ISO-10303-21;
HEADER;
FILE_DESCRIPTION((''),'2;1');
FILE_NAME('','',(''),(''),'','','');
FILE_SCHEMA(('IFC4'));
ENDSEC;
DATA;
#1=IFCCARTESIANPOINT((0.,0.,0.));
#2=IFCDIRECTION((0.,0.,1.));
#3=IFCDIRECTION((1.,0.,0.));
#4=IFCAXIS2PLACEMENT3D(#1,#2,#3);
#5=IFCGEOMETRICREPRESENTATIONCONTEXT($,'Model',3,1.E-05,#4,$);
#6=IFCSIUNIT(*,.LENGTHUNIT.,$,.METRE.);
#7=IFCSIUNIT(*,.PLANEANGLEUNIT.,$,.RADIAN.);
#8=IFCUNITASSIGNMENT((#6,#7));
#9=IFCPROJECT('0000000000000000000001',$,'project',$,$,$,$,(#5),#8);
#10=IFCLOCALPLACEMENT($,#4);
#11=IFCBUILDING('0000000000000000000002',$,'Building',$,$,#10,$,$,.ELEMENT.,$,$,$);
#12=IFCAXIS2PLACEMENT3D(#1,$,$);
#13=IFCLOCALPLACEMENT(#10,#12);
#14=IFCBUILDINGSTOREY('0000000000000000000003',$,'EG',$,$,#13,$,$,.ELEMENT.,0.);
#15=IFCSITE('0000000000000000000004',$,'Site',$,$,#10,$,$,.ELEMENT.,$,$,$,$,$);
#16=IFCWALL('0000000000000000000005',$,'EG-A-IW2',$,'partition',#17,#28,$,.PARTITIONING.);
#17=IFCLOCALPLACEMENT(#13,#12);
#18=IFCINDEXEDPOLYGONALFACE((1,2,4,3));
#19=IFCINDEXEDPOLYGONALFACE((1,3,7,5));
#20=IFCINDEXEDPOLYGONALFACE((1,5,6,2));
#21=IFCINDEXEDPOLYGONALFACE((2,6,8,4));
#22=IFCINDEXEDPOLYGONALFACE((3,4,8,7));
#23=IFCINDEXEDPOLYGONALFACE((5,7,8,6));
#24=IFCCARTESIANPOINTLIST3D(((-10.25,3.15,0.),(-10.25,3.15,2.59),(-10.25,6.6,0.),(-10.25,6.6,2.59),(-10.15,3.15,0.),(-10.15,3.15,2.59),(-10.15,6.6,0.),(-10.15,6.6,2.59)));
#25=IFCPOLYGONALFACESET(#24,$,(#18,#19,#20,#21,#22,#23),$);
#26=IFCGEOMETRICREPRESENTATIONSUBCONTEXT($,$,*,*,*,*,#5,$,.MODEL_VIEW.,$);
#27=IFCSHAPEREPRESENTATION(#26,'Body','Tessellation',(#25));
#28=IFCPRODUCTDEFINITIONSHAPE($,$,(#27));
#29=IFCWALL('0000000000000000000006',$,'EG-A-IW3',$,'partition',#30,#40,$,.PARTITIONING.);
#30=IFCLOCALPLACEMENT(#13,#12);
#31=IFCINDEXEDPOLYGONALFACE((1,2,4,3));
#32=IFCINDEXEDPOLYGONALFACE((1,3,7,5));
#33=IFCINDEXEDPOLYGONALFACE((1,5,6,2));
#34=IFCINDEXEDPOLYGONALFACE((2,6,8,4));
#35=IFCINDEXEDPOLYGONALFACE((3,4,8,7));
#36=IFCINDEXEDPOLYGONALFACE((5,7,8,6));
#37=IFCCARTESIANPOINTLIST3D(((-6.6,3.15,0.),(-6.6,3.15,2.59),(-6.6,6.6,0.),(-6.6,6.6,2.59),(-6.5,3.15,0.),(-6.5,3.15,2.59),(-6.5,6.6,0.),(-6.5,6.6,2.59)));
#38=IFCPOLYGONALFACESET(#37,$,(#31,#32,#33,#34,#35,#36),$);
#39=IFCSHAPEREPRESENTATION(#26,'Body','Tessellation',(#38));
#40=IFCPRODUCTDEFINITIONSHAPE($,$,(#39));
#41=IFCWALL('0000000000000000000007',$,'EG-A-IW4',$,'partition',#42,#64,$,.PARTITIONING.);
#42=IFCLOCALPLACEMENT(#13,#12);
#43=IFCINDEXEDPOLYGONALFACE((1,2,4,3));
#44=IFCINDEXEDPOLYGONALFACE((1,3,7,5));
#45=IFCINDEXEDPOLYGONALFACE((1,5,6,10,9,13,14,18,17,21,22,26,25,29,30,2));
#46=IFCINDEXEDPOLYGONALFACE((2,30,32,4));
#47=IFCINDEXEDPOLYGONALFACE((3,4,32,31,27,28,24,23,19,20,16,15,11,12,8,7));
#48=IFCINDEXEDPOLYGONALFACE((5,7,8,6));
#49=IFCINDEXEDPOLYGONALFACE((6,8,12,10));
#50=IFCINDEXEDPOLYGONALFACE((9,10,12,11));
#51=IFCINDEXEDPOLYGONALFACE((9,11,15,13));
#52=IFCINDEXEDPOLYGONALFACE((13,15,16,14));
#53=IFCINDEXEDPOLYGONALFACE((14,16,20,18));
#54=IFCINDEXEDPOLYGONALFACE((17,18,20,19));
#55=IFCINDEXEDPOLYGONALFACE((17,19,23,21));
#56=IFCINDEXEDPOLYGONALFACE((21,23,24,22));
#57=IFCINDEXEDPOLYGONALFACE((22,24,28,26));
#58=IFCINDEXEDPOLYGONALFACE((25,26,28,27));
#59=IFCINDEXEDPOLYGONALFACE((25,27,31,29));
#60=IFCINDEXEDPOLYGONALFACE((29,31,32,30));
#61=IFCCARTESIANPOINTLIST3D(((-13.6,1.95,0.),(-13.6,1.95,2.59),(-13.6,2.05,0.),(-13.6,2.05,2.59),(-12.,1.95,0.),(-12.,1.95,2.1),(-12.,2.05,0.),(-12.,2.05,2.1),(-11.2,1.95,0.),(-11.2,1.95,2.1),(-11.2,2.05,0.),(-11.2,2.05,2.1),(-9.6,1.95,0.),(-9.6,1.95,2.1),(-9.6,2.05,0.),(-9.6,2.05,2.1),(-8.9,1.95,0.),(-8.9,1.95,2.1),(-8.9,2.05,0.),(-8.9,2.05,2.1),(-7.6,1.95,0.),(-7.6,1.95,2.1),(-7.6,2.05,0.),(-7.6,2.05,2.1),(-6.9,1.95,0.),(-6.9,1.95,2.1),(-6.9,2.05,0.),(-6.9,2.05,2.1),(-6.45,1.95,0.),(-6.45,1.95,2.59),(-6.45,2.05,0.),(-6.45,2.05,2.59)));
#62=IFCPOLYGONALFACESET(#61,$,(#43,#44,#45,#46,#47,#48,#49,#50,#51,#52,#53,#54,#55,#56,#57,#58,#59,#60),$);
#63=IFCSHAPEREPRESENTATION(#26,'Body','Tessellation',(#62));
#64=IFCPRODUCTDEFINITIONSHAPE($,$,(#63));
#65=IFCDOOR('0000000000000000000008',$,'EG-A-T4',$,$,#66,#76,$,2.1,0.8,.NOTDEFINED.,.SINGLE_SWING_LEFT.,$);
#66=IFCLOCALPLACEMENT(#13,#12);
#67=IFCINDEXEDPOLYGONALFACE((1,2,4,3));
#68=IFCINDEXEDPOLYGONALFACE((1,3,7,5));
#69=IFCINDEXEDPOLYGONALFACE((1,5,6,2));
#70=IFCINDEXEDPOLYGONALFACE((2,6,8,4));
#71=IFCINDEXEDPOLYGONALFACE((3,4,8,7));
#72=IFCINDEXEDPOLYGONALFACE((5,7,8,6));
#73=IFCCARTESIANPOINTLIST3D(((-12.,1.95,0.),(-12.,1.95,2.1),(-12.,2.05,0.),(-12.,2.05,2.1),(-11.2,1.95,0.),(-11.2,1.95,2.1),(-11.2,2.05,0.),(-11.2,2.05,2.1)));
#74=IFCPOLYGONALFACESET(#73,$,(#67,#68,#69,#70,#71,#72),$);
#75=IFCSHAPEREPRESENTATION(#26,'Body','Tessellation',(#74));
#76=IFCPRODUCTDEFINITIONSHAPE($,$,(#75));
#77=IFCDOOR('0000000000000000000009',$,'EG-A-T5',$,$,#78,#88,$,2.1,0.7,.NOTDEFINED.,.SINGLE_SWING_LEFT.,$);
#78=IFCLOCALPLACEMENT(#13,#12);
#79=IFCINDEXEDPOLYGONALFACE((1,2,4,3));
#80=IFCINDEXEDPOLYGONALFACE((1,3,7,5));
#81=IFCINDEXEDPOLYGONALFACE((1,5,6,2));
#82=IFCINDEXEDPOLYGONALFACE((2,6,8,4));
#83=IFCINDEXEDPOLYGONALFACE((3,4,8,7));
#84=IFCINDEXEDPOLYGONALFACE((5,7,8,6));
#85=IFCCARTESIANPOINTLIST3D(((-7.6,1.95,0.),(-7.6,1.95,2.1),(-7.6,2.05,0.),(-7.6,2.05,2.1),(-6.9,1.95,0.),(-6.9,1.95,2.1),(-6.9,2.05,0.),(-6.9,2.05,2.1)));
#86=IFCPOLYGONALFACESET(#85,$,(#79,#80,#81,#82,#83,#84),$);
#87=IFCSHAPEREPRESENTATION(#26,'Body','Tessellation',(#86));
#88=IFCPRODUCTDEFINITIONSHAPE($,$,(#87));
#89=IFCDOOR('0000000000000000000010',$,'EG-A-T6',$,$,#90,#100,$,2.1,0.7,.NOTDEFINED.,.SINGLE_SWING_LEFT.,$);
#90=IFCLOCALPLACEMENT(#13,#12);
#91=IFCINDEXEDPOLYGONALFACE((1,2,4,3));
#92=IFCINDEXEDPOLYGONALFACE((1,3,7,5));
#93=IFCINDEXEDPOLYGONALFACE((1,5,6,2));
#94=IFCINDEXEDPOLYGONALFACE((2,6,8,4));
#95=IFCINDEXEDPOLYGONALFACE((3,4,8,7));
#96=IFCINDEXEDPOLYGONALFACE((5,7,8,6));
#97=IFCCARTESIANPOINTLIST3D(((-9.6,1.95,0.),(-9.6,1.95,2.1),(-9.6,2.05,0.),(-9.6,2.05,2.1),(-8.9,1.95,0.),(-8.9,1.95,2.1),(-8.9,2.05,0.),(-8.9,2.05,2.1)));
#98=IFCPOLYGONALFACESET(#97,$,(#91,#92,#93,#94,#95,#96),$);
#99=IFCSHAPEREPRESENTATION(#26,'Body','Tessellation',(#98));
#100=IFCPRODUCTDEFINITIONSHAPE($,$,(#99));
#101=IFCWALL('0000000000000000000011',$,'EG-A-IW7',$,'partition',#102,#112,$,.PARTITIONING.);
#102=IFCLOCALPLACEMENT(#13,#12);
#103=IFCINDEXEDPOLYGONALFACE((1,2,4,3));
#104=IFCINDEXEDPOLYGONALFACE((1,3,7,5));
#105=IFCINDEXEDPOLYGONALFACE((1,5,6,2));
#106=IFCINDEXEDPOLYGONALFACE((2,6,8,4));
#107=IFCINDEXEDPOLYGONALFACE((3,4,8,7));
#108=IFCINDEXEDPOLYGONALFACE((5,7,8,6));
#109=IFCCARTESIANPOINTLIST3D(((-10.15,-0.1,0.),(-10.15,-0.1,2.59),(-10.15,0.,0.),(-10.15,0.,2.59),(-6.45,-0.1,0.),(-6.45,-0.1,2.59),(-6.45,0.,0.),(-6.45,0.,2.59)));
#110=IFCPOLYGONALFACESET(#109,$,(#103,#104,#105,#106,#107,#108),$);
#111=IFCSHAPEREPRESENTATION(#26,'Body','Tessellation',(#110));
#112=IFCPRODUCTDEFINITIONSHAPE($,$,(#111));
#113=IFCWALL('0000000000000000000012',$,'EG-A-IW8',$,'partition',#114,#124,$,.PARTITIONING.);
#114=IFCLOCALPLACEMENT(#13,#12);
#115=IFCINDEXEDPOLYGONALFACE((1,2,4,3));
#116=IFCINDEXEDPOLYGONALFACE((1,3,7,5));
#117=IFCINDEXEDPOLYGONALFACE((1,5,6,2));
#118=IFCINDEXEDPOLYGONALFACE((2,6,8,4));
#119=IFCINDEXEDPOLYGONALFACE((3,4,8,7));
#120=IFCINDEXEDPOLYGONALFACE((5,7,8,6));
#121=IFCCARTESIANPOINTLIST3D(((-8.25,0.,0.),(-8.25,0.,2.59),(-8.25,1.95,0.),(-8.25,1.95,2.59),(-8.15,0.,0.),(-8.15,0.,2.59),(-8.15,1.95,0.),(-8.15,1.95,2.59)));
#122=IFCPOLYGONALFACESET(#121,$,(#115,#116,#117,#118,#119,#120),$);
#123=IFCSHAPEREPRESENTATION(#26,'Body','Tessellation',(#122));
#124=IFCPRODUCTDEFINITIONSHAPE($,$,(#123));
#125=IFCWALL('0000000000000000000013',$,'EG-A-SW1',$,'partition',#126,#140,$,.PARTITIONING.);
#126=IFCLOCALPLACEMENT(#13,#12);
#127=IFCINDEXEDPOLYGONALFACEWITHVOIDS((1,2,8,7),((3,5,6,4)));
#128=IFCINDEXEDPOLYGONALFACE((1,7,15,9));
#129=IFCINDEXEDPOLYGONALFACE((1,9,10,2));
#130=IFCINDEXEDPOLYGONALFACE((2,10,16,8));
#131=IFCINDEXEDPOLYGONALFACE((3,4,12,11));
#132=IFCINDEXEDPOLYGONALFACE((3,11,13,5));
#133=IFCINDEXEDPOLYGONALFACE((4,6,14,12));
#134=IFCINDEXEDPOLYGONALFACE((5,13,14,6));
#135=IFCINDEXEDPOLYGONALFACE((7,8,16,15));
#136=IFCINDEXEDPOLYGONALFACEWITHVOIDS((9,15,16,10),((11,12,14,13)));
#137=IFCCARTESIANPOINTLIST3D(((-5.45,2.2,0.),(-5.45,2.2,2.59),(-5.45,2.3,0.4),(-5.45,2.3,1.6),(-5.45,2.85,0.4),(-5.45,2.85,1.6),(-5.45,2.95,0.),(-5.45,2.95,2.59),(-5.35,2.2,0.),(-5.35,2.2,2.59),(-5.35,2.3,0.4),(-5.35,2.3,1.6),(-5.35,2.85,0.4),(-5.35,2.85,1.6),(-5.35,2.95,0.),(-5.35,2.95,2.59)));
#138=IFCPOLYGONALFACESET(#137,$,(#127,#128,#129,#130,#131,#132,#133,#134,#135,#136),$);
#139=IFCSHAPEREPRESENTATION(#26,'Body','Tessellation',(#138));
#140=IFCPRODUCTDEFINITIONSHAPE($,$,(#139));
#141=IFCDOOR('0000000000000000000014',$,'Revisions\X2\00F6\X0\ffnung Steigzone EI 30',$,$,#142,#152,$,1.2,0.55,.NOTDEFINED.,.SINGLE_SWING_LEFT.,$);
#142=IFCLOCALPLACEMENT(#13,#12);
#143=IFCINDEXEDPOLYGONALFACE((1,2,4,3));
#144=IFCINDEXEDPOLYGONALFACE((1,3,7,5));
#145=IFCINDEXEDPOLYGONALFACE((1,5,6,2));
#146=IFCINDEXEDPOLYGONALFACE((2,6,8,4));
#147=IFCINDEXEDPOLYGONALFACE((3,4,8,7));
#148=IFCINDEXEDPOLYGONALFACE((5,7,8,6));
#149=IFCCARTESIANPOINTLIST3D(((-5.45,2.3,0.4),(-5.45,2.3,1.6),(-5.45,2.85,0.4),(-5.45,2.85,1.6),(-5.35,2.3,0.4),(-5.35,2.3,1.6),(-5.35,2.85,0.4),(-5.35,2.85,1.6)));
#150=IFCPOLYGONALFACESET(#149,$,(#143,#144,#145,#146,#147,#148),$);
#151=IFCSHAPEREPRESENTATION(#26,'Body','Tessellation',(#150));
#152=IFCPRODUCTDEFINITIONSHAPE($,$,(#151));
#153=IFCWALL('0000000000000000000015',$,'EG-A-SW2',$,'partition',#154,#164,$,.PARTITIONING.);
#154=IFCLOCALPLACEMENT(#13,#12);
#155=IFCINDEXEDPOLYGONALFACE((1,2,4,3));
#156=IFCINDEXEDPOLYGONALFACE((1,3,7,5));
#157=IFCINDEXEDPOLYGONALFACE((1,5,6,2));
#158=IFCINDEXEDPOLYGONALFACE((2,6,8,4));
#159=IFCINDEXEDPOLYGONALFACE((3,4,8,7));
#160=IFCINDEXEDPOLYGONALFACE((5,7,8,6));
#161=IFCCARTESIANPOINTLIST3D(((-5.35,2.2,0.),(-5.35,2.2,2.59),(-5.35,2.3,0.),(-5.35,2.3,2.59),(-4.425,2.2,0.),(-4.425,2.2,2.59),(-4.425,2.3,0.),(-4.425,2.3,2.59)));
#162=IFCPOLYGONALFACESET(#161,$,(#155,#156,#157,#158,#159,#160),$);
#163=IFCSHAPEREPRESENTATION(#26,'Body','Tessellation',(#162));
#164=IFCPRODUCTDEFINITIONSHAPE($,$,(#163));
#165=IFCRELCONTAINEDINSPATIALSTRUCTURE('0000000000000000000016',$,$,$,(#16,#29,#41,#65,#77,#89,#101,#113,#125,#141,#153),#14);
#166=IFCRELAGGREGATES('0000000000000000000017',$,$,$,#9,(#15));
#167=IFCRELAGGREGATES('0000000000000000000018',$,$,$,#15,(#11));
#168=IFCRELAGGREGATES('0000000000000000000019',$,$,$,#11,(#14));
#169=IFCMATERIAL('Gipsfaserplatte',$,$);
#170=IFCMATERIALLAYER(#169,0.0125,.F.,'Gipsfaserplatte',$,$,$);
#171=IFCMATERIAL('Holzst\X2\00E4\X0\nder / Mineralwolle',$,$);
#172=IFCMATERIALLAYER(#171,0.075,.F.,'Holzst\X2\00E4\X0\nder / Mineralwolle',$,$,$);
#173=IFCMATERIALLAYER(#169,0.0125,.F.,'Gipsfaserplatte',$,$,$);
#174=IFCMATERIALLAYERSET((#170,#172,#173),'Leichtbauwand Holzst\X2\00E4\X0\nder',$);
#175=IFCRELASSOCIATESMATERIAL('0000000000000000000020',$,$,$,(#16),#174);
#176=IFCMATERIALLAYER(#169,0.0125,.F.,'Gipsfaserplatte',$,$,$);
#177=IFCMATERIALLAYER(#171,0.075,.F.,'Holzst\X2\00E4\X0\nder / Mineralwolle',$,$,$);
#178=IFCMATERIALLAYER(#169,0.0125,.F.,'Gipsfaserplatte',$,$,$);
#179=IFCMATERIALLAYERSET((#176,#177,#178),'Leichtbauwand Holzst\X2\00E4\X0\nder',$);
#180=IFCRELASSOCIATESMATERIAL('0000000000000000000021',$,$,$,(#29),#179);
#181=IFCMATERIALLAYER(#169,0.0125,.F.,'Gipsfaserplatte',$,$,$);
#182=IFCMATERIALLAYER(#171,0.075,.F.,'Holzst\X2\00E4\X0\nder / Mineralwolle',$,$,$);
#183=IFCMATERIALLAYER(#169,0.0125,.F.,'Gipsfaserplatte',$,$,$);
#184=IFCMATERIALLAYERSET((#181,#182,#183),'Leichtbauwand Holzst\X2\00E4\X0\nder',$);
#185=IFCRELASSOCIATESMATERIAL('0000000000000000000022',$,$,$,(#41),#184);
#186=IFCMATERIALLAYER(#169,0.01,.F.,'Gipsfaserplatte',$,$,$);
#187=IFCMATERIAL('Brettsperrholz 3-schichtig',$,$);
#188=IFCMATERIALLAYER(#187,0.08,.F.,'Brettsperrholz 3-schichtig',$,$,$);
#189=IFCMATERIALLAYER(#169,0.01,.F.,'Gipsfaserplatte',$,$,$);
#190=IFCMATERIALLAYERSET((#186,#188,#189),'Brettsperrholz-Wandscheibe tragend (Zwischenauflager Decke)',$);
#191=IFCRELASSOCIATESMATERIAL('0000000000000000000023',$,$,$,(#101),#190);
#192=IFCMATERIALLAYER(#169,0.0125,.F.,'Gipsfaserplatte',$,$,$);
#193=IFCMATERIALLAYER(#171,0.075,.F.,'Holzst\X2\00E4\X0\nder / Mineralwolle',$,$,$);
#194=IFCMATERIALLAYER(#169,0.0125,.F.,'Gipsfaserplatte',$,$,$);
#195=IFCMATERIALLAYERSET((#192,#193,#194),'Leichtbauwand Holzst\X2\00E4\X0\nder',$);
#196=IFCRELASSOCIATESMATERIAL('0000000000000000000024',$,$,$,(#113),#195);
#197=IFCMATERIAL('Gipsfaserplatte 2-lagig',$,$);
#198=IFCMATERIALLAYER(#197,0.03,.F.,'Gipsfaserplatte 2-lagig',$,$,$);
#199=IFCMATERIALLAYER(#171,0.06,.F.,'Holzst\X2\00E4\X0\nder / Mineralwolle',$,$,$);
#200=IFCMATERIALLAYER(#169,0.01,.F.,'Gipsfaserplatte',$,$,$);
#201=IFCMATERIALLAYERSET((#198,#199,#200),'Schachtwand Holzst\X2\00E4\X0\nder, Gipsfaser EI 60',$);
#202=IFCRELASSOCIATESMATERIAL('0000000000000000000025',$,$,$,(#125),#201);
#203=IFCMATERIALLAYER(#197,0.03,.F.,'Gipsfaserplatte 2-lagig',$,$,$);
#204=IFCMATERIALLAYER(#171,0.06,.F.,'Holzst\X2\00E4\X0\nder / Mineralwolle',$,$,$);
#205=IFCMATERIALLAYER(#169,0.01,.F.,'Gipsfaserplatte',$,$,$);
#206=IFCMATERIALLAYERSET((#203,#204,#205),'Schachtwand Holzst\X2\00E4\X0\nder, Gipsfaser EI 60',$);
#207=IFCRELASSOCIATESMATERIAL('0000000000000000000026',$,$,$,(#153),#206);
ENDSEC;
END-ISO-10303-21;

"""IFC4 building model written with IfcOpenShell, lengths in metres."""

from ifc_helpers import new_model, si_unit, frame, frame_2d, origin, origin_with_axes, place, context, subcontext, project, spatial, rectangle, extrude, material, layer, layer_set, element, fill, save


model = new_model("IFC4")

# Units and contexts
model_context = context("Model", 3, precision=1e-05, world=origin_with_axes())
sub_context = subcontext(model_context, None, None, "MODEL_VIEW")
ifc_project = project(units=[si_unit("LENGTHUNIT", "METRE"), si_unit("PLANEANGLEUNIT", "RADIAN")], contexts=[model_context])

# Site, building, storey
placement = place(None, origin_with_axes())
site = spatial("IfcSite", under=ifc_project, at=placement, Name="Site", CompositionType="ELEMENT")
building = spatial("IfcBuilding", under=site, at=placement, Name="Building", CompositionType="ELEMENT")
storey_placement = place(placement, origin())
storey = spatial("IfcBuildingStorey", under=building, at=storey_placement, Name="EG", CompositionType="ELEMENT", Elevation=0.0)

# Shared definitions
ifc_material_1 = material(Name="Gipsfaserplatte")

# Shared definitions
ifc_material_2 = material(Name="Gipsfaserplatte 2-lagig")

# Walls
ifc_layer_1 = layer(ifc_material_1, 0.0125, ventilated=False, Name="Gipsfaserplatte")
ifc_material_3 = material(Name="Holzständer / Mineralwolle")
ifc_layer_2 = layer(ifc_material_3, 0.075, ventilated=False, Name="Holzständer / Mineralwolle")
ifc_layer_3 = layer(ifc_material_1, 0.0125, ventilated=False, Name="Gipsfaserplatte")
ifc_layer_set_1 = layer_set([ifc_layer_1, ifc_layer_2, ifc_layer_3], Name="Leichtbauwand Holzständer")
wall_1_placement = place(storey_placement, frame((-10.2, 3.15, 0.0), z_axis=(0.0, 0.0, 1.0), x_axis=(0.0, 1.0, 0.0)))
element("IfcWall", 1, at=wall_1_placement, inside=storey, material=ifc_layer_set_1, Name="EG-A-IW2", ObjectType="partition", PredefinedType="PARTITIONING", context=sub_context, shape_type="SweptSolid", body=[
    extrude(rectangle(XDim=3.45, YDim=0.1, at=frame_2d((1.725, 0.0))), origin(), (0.0, 0.0, 1.0), 2.59),
])
ifc_layer_4 = layer(ifc_material_1, 0.0125, ventilated=False, Name="Gipsfaserplatte")
ifc_layer_5 = layer(ifc_material_3, 0.075, ventilated=False, Name="Holzständer / Mineralwolle")
ifc_layer_6 = layer(ifc_material_1, 0.0125, ventilated=False, Name="Gipsfaserplatte")
ifc_layer_set_2 = layer_set([ifc_layer_4, ifc_layer_5, ifc_layer_6], Name="Leichtbauwand Holzständer")
wall_2_placement = place(storey_placement, frame((-6.55, 3.15, 0.0), z_axis=(0.0, 0.0, 1.0), x_axis=(0.0, 1.0, 0.0)))
element("IfcWall", 2, at=wall_2_placement, inside=storey, material=ifc_layer_set_2, Name="EG-A-IW3", ObjectType="partition", PredefinedType="PARTITIONING", context=sub_context, shape_type="SweptSolid", body=[
    extrude(rectangle(XDim=3.45, YDim=0.1, at=frame_2d((1.725, 0.0))), origin(), (0.0, 0.0, 1.0), 2.59),
])

# Wall, openings, doors
ifc_layer_7 = layer(ifc_material_1, 0.0125, ventilated=False, Name="Gipsfaserplatte")
ifc_layer_8 = layer(ifc_material_3, 0.075, ventilated=False, Name="Holzständer / Mineralwolle")
ifc_layer_9 = layer(ifc_material_1, 0.0125, ventilated=False, Name="Gipsfaserplatte")
ifc_layer_set_3 = layer_set([ifc_layer_7, ifc_layer_8, ifc_layer_9], Name="Leichtbauwand Holzständer")
wall_3_placement = place(storey_placement, frame((-13.6, 2.0, 0.0), z_axis=(0.0, 0.0, 1.0), x_axis=(1.0, 0.0, 0.0)))
wall_3 = element("IfcWall", 3, at=wall_3_placement, inside=storey, material=ifc_layer_set_3, Name="EG-A-IW4", ObjectType="partition", PredefinedType="PARTITIONING", context=sub_context, shape_type="SweptSolid", body=[
    extrude(rectangle(XDim=7.15, YDim=0.1, at=frame_2d((3.575, 0.0))), origin(), (0.0, 0.0, 1.0), 2.59),
])
opening_1_placement = place(wall_3_placement, frame((2.0, 0.1, 0.0), z_axis=(0.0, -1.0, 0.0), x_axis=(1.0, 0.0, 0.0)))
opening_1 = element("IfcOpeningElement", 4, at=opening_1_placement, cuts=wall_3, PredefinedType="OPENING", context=sub_context, shape_type="SweptSolid", body=[
    extrude(rectangle(XDim=0.8, YDim=2.1, at=frame_2d((0.0, 1.05))), origin(), (0.0, 0.0, 1.0), 0.2),
])
opening_2_placement = place(wall_3_placement, frame((6.35, 0.1, 0.0), z_axis=(0.0, -1.0, 0.0), x_axis=(1.0, 0.0, 0.0)))
opening_2 = element("IfcOpeningElement", 5, at=opening_2_placement, cuts=wall_3, PredefinedType="OPENING", context=sub_context, shape_type="SweptSolid", body=[
    extrude(rectangle(XDim=0.7, YDim=2.1, at=frame_2d((0.0, 1.05))), origin(), (0.0, 0.0, 1.0), 0.2),
])
opening_3_placement = place(wall_3_placement, frame((4.35, 0.1, 0.0), z_axis=(0.0, -1.0, 0.0), x_axis=(1.0, 0.0, 0.0)))
opening_3 = element("IfcOpeningElement", 6, at=opening_3_placement, cuts=wall_3, PredefinedType="OPENING", context=sub_context, shape_type="SweptSolid", body=[
    extrude(rectangle(XDim=0.7, YDim=2.1, at=frame_2d((0.0, 1.05))), origin(), (0.0, 0.0, 1.0), 0.2),
])
door_1_placement = place(wall_3_placement, frame((2.0, 0.05, 0.0), z_axis=(0.0, -1.0, 0.0), x_axis=(1.0, 0.0, 0.0)))
door_1 = element("IfcDoor", 7, at=door_1_placement, inside=storey, Name="EG-A-T4", OperationType="SINGLE_SWING_LEFT", OverallHeight=2.1, OverallWidth=0.8, PredefinedType="NOTDEFINED", context=sub_context, shape_type="SweptSolid", body=[
    extrude(rectangle(XDim=0.8, YDim=2.1, at=frame_2d((0.0, 1.05))), origin(), (0.0, 0.0, 1.0), 0.1),
])
fill(opening_1, door_1)
door_2_placement = place(wall_3_placement, frame((6.35, 0.05, 0.0), z_axis=(0.0, -1.0, 0.0), x_axis=(1.0, 0.0, 0.0)))
door_2 = element("IfcDoor", 8, at=door_2_placement, inside=storey, Name="EG-A-T5", OperationType="SINGLE_SWING_LEFT", OverallHeight=2.1, OverallWidth=0.7, PredefinedType="NOTDEFINED", context=sub_context, shape_type="SweptSolid", body=[
    extrude(rectangle(XDim=0.7, YDim=2.1, at=frame_2d((0.0, 1.05))), origin(), (0.0, 0.0, 1.0), 0.1),
])
fill(opening_2, door_2)
door_3_placement = place(wall_3_placement, frame((4.35, 0.05, 0.0), z_axis=(0.0, -1.0, 0.0), x_axis=(1.0, 0.0, 0.0)))
door_3 = element("IfcDoor", 9, at=door_3_placement, inside=storey, Name="EG-A-T6", OperationType="SINGLE_SWING_LEFT", OverallHeight=2.1, OverallWidth=0.7, PredefinedType="NOTDEFINED", context=sub_context, shape_type="SweptSolid", body=[
    extrude(rectangle(XDim=0.7, YDim=2.1, at=frame_2d((0.0, 1.05))), origin(), (0.0, 0.0, 1.0), 0.1),
])
fill(opening_3, door_3)

# Walls
ifc_layer_10 = layer(ifc_material_1, 0.01, ventilated=False, Name="Gipsfaserplatte")
ifc_material_4 = material(Name="Brettsperrholz 3-schichtig")
ifc_layer_11 = layer(ifc_material_4, 0.08, ventilated=False, Name="Brettsperrholz 3-schichtig")
ifc_layer_12 = layer(ifc_material_1, 0.01, ventilated=False, Name="Gipsfaserplatte")
ifc_layer_set_4 = layer_set([ifc_layer_10, ifc_layer_11, ifc_layer_12], Name="Brettsperrholz-Wandscheibe tragend (Zwischenauflager Decke)")
wall_4_placement = place(storey_placement, frame((-10.15, -0.05, 0.0), z_axis=(0.0, 0.0, 1.0), x_axis=(1.0, 0.0, 0.0)))
element("IfcWall", 10, at=wall_4_placement, inside=storey, material=ifc_layer_set_4, Name="EG-A-IW7", ObjectType="partition", PredefinedType="PARTITIONING", context=sub_context, shape_type="SweptSolid", body=[
    extrude(rectangle(XDim=3.7, YDim=0.1, at=frame_2d((1.85, 0.0))), origin(), (0.0, 0.0, 1.0), 2.59),
])
ifc_layer_13 = layer(ifc_material_1, 0.0125, ventilated=False, Name="Gipsfaserplatte")
ifc_layer_14 = layer(ifc_material_3, 0.075, ventilated=False, Name="Holzständer / Mineralwolle")
ifc_layer_15 = layer(ifc_material_1, 0.0125, ventilated=False, Name="Gipsfaserplatte")
ifc_layer_set_5 = layer_set([ifc_layer_13, ifc_layer_14, ifc_layer_15], Name="Leichtbauwand Holzständer")
wall_5_placement = place(storey_placement, frame((-8.2, 0.0, 0.0), z_axis=(0.0, 0.0, 1.0), x_axis=(0.0, 1.0, 0.0)))
element("IfcWall", 11, at=wall_5_placement, inside=storey, material=ifc_layer_set_5, Name="EG-A-IW8", ObjectType="partition", PredefinedType="PARTITIONING", context=sub_context, shape_type="SweptSolid", body=[
    extrude(rectangle(XDim=1.95, YDim=0.1, at=frame_2d((0.975, 0.0))), origin(), (0.0, 0.0, 1.0), 2.59),
])

# Wall, opening, door
ifc_layer_16 = layer(ifc_material_2, 0.03, ventilated=False, Name="Gipsfaserplatte 2-lagig")
ifc_layer_17 = layer(ifc_material_3, 0.06, ventilated=False, Name="Holzständer / Mineralwolle")
ifc_layer_18 = layer(ifc_material_1, 0.01, ventilated=False, Name="Gipsfaserplatte")
ifc_layer_set_6 = layer_set([ifc_layer_16, ifc_layer_17, ifc_layer_18], Name="Schachtwand Holzständer, Gipsfaser EI 60")
wall_6_placement = place(storey_placement, frame((-5.4, 2.2, 0.0), z_axis=(0.0, 0.0, 1.0), x_axis=(0.0, 1.0, 0.0)))
wall_6 = element("IfcWall", 12, at=wall_6_placement, inside=storey, material=ifc_layer_set_6, Name="EG-A-SW1", ObjectType="partition", PredefinedType="PARTITIONING", context=sub_context, shape_type="SweptSolid", body=[
    extrude(rectangle(XDim=0.75, YDim=0.1, at=frame_2d((0.375, 0.0))), origin(), (0.0, 0.0, 1.0), 2.59),
])
opening_4_placement = place(wall_6_placement, frame((0.375, 0.1, 0.4), z_axis=(0.0, -1.0, 0.0), x_axis=(1.0, 0.0, 0.0)))
opening_4 = element("IfcOpeningElement", 13, at=opening_4_placement, cuts=wall_6, PredefinedType="OPENING", context=sub_context, shape_type="SweptSolid", body=[
    extrude(rectangle(XDim=0.55, YDim=1.2, at=frame_2d((0.0, 0.6))), origin(), (0.0, 0.0, 1.0), 0.2),
])
door_4_placement = place(wall_6_placement, frame((0.375, 0.05, 0.4), z_axis=(0.0, -1.0, 0.0), x_axis=(1.0, 0.0, 0.0)))
door_4 = element("IfcDoor", 14, at=door_4_placement, inside=storey, Name="Revisionsöffnung Steigzone EI 30", OperationType="SINGLE_SWING_LEFT", OverallHeight=1.2, OverallWidth=0.55, PredefinedType="NOTDEFINED", context=sub_context, shape_type="SweptSolid", body=[
    extrude(rectangle(XDim=0.55, YDim=1.2, at=frame_2d((0.0, 0.6))), origin(), (0.0, 0.0, 1.0), 0.1),
])
fill(opening_4, door_4)

# Wall
ifc_layer_19 = layer(ifc_material_2, 0.03, ventilated=False, Name="Gipsfaserplatte 2-lagig")
ifc_layer_20 = layer(ifc_material_3, 0.06, ventilated=False, Name="Holzständer / Mineralwolle")
ifc_layer_21 = layer(ifc_material_1, 0.01, ventilated=False, Name="Gipsfaserplatte")
ifc_layer_set_7 = layer_set([ifc_layer_19, ifc_layer_20, ifc_layer_21], Name="Schachtwand Holzständer, Gipsfaser EI 60")
wall_7_placement = place(storey_placement, frame((-5.35, 2.25, 0.0), z_axis=(0.0, 0.0, 1.0), x_axis=(1.0, 0.0, 0.0)))
element("IfcWall", 15, at=wall_7_placement, inside=storey, material=ifc_layer_set_7, Name="EG-A-SW2", ObjectType="partition", PredefinedType="PARTITIONING", context=sub_context, shape_type="SweptSolid", body=[
    extrude(rectangle(XDim=0.925, YDim=0.1, at=frame_2d((0.4625, 0.0))), origin(), (0.0, 0.0, 1.0), 2.59),
])

save(model, "model.ifc")
